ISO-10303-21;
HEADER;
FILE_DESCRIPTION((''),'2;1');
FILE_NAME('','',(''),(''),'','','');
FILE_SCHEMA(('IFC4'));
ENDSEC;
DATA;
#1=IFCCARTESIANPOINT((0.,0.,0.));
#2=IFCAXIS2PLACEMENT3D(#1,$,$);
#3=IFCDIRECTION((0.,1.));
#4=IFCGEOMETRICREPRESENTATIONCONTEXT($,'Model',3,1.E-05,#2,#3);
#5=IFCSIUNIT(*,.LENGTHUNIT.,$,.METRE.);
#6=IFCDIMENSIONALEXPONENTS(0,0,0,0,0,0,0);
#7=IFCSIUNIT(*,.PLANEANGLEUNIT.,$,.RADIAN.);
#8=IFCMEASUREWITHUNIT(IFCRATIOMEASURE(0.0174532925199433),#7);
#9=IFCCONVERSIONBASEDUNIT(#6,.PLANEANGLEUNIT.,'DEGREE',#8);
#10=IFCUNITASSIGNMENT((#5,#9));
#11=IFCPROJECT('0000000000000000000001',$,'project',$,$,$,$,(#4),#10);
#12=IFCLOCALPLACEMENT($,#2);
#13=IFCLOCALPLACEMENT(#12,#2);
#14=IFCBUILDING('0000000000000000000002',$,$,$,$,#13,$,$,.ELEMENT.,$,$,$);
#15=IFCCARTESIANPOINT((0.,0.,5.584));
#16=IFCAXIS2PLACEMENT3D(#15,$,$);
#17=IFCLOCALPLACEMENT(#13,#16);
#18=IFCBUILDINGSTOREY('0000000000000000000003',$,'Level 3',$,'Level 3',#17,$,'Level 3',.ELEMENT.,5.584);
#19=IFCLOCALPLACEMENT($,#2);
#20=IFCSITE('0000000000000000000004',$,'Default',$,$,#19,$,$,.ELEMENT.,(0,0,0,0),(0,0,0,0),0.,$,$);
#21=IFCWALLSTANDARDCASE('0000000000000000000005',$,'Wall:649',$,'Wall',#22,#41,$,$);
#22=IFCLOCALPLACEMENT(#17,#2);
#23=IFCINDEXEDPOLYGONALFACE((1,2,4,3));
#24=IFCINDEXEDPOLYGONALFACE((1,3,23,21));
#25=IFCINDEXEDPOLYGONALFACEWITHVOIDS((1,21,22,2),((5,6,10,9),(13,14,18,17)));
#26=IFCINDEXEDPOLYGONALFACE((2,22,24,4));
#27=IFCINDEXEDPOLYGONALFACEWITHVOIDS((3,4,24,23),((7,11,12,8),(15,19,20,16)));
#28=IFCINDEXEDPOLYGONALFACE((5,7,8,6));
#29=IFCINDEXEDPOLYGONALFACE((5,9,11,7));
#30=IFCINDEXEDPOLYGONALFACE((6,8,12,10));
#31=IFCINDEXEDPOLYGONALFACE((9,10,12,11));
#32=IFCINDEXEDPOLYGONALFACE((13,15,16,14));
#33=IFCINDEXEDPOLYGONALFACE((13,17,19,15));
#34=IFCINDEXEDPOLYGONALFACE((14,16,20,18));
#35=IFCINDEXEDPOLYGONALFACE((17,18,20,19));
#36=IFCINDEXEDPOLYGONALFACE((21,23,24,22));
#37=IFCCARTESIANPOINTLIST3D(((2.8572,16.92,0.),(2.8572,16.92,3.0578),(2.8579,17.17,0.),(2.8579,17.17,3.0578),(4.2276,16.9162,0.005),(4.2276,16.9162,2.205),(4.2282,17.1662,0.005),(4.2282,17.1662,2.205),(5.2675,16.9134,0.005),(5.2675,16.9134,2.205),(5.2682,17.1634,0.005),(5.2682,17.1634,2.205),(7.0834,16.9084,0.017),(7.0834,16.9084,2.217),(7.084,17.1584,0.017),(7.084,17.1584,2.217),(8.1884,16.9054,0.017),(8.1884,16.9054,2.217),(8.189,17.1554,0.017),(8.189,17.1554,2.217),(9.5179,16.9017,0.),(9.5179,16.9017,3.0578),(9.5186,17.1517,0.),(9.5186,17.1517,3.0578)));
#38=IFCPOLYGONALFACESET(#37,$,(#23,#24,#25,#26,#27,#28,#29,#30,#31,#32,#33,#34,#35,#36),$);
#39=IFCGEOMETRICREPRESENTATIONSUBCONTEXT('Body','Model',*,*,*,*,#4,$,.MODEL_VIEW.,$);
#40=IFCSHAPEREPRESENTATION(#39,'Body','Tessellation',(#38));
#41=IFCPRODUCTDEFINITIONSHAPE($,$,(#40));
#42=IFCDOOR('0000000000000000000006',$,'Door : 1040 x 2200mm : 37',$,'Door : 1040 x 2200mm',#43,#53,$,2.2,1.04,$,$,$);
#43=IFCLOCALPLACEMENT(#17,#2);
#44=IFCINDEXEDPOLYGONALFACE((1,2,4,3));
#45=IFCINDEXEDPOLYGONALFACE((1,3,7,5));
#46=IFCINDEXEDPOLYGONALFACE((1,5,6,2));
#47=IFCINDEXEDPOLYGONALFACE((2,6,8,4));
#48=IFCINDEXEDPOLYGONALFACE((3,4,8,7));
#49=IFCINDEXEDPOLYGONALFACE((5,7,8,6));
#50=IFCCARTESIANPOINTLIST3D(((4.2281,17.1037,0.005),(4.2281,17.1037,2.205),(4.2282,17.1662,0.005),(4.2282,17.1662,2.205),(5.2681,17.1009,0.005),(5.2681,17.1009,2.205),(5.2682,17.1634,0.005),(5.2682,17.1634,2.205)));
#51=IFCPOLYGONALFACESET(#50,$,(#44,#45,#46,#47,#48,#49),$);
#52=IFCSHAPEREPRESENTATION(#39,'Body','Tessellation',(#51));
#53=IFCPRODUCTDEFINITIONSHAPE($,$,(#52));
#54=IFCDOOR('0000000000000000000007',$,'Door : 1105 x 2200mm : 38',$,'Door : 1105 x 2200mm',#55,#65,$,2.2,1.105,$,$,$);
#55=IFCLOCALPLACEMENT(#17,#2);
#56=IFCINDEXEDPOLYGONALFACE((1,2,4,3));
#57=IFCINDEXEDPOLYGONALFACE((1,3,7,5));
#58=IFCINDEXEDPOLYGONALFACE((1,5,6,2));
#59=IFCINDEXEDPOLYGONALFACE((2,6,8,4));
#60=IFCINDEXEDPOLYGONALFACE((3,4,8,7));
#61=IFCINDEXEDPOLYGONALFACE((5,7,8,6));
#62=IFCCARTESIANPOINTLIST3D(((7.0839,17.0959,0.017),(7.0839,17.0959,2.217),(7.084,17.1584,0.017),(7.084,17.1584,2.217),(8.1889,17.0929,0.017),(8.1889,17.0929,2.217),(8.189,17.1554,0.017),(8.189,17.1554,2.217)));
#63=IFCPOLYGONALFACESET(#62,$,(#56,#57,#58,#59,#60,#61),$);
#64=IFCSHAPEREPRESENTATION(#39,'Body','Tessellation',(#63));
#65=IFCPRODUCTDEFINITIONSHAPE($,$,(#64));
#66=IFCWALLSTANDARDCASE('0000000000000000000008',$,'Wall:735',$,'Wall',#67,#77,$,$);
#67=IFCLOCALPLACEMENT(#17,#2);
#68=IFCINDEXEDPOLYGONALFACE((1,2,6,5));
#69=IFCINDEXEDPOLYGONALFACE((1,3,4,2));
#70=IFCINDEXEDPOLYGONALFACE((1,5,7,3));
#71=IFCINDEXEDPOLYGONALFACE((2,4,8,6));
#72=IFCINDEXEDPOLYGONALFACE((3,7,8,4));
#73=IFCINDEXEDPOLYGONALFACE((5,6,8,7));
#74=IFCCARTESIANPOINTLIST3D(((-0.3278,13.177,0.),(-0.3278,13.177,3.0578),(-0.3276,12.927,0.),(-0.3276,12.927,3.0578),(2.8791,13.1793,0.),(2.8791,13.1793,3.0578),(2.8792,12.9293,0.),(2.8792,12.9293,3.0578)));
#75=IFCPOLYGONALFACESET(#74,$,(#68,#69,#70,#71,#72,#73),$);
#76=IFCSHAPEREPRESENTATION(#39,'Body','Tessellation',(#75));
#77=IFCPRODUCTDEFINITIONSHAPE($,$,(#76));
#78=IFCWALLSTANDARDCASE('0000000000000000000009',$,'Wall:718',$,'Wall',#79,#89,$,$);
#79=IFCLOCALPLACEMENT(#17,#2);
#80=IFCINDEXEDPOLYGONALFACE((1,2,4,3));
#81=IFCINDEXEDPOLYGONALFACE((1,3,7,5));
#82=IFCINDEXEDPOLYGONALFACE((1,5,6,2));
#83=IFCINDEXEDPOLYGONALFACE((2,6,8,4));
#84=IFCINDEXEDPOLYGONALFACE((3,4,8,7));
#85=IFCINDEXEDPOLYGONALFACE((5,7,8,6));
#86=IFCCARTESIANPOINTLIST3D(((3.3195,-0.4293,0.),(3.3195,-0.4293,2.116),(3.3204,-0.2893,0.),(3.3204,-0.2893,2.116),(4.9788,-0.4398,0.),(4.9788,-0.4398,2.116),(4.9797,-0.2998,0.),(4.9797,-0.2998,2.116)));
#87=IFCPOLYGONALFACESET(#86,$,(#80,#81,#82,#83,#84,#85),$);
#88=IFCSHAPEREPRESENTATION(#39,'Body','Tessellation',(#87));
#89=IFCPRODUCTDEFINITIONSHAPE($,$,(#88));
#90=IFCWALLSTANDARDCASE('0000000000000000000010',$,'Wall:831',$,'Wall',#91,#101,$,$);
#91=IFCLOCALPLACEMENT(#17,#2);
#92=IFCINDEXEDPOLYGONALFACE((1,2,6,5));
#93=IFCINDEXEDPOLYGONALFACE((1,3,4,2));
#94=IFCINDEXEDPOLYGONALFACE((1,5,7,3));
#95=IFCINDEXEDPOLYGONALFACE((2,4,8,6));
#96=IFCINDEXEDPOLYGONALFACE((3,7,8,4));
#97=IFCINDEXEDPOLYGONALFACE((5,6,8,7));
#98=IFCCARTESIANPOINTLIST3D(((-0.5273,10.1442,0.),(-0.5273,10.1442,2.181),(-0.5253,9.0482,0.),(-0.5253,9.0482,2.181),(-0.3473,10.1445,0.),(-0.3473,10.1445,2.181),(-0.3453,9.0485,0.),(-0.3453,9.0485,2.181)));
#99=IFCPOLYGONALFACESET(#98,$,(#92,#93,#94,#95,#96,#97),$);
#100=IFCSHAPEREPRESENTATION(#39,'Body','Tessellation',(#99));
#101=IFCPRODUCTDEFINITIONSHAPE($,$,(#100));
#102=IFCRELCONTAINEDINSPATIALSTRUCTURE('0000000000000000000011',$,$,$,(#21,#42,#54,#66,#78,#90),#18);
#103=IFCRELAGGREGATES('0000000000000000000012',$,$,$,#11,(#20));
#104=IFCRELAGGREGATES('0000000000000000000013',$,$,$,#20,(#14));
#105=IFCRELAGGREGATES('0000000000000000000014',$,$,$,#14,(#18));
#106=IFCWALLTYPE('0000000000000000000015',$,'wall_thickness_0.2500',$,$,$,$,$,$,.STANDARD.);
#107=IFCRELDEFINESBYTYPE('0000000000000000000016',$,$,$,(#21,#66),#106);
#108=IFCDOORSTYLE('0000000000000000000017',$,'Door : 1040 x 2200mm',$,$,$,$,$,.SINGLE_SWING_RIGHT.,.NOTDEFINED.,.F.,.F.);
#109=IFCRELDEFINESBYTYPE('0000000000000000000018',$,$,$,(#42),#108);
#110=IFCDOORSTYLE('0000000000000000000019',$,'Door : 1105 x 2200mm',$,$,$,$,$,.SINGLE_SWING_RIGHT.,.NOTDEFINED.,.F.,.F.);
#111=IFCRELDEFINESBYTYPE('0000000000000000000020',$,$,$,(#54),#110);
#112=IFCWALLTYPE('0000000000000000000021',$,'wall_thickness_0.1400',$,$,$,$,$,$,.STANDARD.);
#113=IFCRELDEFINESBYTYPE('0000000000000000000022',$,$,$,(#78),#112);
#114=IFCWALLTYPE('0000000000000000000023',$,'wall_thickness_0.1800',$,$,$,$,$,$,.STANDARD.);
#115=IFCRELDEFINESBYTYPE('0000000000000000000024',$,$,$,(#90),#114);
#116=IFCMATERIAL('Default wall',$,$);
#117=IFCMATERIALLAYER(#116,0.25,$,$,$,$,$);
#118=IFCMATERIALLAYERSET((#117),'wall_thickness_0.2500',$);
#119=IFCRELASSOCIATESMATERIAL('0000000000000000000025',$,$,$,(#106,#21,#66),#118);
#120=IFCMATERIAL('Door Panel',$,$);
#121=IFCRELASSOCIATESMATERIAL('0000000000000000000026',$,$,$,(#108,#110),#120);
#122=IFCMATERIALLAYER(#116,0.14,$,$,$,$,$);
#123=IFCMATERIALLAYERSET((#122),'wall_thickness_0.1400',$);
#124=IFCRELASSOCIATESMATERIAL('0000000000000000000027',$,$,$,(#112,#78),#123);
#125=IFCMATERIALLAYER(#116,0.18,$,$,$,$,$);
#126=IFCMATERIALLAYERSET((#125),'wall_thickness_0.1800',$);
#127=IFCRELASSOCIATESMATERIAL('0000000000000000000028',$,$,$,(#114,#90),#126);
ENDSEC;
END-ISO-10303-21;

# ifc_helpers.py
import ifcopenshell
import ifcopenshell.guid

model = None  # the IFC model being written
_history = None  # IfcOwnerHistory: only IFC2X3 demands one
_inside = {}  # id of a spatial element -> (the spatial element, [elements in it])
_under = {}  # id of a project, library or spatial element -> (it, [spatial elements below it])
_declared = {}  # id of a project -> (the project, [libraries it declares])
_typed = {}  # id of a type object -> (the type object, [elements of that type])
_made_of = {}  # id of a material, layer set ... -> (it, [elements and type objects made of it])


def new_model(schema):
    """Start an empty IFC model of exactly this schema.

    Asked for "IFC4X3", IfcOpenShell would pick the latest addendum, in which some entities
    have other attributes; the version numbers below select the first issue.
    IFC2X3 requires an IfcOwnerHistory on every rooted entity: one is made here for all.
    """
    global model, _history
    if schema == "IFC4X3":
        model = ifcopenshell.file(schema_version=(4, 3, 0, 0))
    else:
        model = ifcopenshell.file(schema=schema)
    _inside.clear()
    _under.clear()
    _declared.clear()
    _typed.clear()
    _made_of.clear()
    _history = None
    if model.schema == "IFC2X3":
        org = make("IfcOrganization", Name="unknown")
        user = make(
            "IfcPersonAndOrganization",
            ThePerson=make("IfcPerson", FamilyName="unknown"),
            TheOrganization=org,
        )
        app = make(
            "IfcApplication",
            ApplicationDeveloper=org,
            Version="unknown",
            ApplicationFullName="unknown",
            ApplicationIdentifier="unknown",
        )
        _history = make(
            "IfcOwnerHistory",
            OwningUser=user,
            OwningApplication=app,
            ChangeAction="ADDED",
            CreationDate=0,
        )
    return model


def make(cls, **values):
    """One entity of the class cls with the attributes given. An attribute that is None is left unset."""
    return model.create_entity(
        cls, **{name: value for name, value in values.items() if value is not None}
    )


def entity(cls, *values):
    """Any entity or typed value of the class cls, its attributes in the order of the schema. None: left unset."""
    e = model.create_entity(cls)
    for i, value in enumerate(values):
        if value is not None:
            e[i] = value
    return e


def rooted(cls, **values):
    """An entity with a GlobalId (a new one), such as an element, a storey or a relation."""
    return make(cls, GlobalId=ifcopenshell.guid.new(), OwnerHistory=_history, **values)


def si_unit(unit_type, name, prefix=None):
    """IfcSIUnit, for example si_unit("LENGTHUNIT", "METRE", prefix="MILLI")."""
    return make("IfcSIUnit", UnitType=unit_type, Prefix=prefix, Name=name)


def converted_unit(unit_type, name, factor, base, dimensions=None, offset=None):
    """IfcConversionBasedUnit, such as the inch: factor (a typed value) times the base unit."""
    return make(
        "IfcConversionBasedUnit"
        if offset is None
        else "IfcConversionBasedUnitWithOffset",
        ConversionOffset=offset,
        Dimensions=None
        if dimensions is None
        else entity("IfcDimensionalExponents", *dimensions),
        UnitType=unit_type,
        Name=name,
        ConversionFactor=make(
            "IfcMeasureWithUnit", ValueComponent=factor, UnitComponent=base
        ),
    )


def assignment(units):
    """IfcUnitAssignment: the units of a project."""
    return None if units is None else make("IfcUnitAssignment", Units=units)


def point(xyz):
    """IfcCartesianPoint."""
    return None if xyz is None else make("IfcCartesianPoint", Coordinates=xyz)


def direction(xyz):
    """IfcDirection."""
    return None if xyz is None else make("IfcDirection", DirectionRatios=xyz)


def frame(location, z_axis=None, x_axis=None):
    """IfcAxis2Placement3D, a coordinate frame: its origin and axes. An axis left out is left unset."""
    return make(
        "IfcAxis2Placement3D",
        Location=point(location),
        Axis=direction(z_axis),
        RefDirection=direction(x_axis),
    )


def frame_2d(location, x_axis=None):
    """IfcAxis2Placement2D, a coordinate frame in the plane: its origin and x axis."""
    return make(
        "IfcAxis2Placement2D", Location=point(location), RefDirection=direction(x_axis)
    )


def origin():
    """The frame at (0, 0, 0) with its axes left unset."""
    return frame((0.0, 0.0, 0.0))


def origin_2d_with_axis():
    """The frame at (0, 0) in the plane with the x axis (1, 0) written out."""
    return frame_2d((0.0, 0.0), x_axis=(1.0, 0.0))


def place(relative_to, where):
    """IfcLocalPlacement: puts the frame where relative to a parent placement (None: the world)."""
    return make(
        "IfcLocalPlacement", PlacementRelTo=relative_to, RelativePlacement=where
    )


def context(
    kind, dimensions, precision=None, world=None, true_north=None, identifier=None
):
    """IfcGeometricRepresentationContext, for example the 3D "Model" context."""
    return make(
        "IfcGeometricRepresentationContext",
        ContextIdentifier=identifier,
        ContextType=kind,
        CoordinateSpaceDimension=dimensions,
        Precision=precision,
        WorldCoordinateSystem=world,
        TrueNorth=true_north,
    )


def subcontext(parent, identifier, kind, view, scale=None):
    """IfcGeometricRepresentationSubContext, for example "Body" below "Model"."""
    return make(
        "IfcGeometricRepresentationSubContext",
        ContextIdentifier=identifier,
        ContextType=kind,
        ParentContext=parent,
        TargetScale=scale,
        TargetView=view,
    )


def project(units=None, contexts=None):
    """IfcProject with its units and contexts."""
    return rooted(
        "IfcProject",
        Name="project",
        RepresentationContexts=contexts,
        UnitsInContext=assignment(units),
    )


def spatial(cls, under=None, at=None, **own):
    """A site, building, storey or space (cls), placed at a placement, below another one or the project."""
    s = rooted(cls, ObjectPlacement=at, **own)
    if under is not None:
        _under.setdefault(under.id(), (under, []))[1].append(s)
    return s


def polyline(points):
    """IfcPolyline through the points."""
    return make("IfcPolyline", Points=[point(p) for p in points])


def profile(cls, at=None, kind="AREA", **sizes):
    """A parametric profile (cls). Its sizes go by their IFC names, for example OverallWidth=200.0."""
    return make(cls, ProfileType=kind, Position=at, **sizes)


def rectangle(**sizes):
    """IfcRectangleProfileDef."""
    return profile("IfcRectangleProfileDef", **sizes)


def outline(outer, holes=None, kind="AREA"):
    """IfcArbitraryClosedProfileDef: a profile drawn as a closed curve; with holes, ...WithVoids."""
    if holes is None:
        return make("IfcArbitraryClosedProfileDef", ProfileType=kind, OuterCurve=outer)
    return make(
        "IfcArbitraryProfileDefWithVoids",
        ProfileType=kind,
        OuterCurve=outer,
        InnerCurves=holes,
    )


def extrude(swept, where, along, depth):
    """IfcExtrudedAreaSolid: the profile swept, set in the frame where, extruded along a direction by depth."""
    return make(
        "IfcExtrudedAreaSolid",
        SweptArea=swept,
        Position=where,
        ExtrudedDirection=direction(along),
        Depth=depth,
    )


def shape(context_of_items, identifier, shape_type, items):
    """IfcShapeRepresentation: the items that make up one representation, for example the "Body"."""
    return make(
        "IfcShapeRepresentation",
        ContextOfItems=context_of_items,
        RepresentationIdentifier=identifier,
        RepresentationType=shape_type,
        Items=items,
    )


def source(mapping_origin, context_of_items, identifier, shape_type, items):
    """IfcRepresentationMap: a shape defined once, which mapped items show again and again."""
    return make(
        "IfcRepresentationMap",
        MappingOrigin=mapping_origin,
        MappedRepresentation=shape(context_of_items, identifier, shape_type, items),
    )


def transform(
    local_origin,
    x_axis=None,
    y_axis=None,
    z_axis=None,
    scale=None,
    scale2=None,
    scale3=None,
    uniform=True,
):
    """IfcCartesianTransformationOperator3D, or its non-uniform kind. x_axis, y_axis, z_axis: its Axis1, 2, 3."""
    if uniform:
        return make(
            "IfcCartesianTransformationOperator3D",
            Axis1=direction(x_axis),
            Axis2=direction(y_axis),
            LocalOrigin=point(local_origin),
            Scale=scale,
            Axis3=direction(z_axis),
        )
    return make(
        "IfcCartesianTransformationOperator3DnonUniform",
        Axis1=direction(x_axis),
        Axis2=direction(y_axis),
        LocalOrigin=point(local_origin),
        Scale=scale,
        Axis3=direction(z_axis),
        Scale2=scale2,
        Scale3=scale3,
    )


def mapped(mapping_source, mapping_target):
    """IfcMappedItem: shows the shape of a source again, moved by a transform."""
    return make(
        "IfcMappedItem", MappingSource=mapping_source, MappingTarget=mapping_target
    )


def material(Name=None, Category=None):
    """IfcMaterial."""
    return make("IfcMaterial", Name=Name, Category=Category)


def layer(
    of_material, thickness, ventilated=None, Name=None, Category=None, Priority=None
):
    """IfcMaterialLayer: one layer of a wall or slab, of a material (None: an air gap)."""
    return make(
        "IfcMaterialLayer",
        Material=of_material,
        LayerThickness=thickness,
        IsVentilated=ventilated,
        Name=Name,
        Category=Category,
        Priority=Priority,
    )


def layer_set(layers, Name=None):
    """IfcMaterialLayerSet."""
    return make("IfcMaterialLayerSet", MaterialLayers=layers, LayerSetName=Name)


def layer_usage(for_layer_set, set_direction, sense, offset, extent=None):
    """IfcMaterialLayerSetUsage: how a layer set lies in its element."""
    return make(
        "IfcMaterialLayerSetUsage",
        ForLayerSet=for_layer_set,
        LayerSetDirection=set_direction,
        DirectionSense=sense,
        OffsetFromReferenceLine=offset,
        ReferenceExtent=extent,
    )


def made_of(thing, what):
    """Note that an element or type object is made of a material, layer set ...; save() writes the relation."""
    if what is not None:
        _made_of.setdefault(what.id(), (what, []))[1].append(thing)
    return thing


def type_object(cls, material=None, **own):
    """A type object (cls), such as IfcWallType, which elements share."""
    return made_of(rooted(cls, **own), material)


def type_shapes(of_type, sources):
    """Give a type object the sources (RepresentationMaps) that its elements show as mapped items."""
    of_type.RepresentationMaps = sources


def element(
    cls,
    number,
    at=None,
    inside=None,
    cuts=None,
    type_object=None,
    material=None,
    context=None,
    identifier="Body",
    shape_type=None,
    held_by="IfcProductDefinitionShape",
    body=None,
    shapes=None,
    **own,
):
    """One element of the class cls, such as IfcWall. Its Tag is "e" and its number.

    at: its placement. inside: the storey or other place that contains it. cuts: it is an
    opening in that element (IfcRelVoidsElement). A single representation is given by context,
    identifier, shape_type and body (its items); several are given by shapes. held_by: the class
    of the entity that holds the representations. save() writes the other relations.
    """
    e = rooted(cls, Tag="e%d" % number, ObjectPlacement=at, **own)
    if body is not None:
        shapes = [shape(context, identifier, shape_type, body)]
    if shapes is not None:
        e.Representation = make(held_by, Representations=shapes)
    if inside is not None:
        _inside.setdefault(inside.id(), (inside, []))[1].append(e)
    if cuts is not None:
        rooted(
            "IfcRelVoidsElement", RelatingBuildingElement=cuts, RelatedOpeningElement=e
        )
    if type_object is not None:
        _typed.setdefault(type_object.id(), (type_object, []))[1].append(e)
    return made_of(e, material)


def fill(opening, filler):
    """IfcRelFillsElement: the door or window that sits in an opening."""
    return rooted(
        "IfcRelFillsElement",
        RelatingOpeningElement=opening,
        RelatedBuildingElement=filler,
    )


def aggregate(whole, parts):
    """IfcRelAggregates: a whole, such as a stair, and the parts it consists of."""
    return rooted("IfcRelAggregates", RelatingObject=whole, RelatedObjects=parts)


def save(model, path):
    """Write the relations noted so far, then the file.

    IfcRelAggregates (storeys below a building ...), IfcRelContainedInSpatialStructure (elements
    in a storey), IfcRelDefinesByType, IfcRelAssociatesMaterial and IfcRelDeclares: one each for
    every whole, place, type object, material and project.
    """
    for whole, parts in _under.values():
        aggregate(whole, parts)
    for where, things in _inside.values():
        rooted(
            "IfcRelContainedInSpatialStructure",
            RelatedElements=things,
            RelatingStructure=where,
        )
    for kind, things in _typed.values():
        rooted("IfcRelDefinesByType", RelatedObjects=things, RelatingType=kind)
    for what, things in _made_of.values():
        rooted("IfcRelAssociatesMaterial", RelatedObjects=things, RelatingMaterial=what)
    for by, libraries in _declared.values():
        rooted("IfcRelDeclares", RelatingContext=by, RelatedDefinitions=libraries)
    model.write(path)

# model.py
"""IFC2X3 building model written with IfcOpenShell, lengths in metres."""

from ifc_helpers import new_model, entity, si_unit, converted_unit, direction, frame, frame_2d, origin, origin_2d_with_axis, place, context, subcontext, project, spatial, polyline, rectangle, outline, extrude, source, transform, mapped, material, layer, layer_set, layer_usage, type_object, type_shapes, element, fill, save


model = new_model("IFC2X3")

# Units and contexts
model_context = context("Model", 3, precision=1e-05, world=origin(), true_north=direction((0.0, 1.0)))
body_context = subcontext(model_context, "Body", "Model", "MODEL_VIEW")
ifc_project = project(units=[si_unit("LENGTHUNIT", "METRE"), converted_unit("PLANEANGLEUNIT", "DEGREE", entity("IfcRatioMeasure", 0.0174532925199433), si_unit("PLANEANGLEUNIT", "RADIAN"), dimensions=[0, 0, 0, 0, 0, 0, 0])], contexts=[model_context])

# Site, building, storey
site_placement = place(None, origin())
site = spatial("IfcSite", under=ifc_project, at=site_placement, Name="Default", CompositionType="ELEMENT", RefLatitude=(0, 0, 0, 0), RefLongitude=(0, 0, 0, 0), RefElevation=0.0)
placement_1 = place(None, origin())
building_placement = place(placement_1, origin())
building = spatial("IfcBuilding", under=site, at=building_placement, CompositionType="ELEMENT")
storey_placement = place(building_placement, frame((0.0, 0.0, 5.584)))
storey = spatial("IfcBuildingStorey", under=building, at=storey_placement, Name="Level 3", ObjectType="Level 3", LongName="Level 3", CompositionType="ELEMENT", Elevation=5.584)

# Shared definitions
ifc_material_1 = material(Name="Default wall")

# Wall, openings, doors
ifc_layer_1 = layer(ifc_material_1, 0.25)
ifc_layer_set_1 = layer_set([ifc_layer_1], Name="wall_thickness_0.2500")
ifc_layer_usage_1 = layer_usage(ifc_layer_set_1, "AXIS2", "POSITIVE", -0.125)
wall_type_1 = type_object("IfcWallType", Name="wall_thickness_0.2500", PredefinedType="STANDARD", material=ifc_layer_set_1)
wall_1_placement = place(storey_placement, frame((2.8576, 17.045, 0.0), z_axis=(0.0, 0.0, 1.0), x_axis=(0.999996, -0.002747, 0.0)))
wall_1 = element("IfcWallStandardCase", 1, at=wall_1_placement, inside=storey, type_object=wall_type_1, material=ifc_layer_usage_1, Name="Wall:649", ObjectType="Wall", context=body_context, shape_type="SweptSolid", body=[
    extrude(outline(polyline([(6.6607, -0.125), (6.6607, 0.125), (0.0, 0.125), (0.0, -0.125), (6.6607, -0.125)])), origin(), (0.0, 0.0, 1.0), 3.0578),
])
opening_1_placement = place(wall_1_placement, frame((1.3703, -0.125, 0.005)))
opening_1 = element("IfcOpeningElement", 2, at=opening_1_placement, cuts=wall_1, ObjectType="Opening", context=body_context, shape_type="SweptSolid", body=[
    extrude(rectangle(XDim=1.04, YDim=2.2, at=frame_2d((1.1, 0.52), x_axis=(0.0, 1.0))), frame((0.0, 0.0, 0.0), z_axis=(0.0, 1.0, 0.0), x_axis=(0.0, 0.0, 1.0)), (0.0, 0.0, 1.0), 0.25),
])
opening_2_placement = place(wall_1_placement, frame((4.2261, -0.125, 0.017)))
opening_2 = element("IfcOpeningElement", 3, at=opening_2_placement, cuts=wall_1, ObjectType="Opening", context=body_context, shape_type="SweptSolid", body=[
    extrude(rectangle(XDim=1.105, YDim=2.2, at=frame_2d((1.1, 0.5525), x_axis=(0.0, 1.0))), frame((0.0, 0.0, 0.0), z_axis=(0.0, 1.0, 0.0), x_axis=(0.0, 0.0, 1.0)), (0.0, 0.0, 1.0), 0.25),
])
ifc_material_2 = material(Name="Door Panel")
door_style_1 = type_object("IfcDoorStyle", Name="Door : 1040 x 2200mm", ConstructionType="NOTDEFINED", OperationType="SINGLE_SWING_RIGHT", ParameterTakesPrecedence=False, Sizeable=False, material=ifc_material_2)
shared_shape_1 = source(origin(), body_context, "Body", "SweptSolid", [
    extrude(rectangle(XDim=0.0625, YDim=1.04, at=origin_2d_with_axis()), frame((0.52, 0.2188, 0.0), z_axis=(0.0, 0.0, 1.0), x_axis=(0.0, 1.0, 0.0)), (0.0, 0.0, 1.0), 2.2),
])
type_shapes(door_style_1, [shared_shape_1])
door_1_placement = place(opening_1_placement, origin())
door_1 = element("IfcDoor", 4, at=door_1_placement, inside=storey, type_object=door_style_1, Name="Door : 1040 x 2200mm : 37", ObjectType="Door : 1040 x 2200mm", OverallHeight=2.2, OverallWidth=1.04, context=body_context, shape_type="MappedRepresentation", body=[
    mapped(shared_shape_1, transform((0.0, 0.0, 0.0), scale=1.0)),
])
fill(opening_1, door_1)
door_style_2 = type_object("IfcDoorStyle", Name="Door : 1105 x 2200mm", ConstructionType="NOTDEFINED", OperationType="SINGLE_SWING_RIGHT", ParameterTakesPrecedence=False, Sizeable=False, material=ifc_material_2)
shared_shape_2 = source(origin(), body_context, "Body", "SweptSolid", [
    extrude(rectangle(XDim=0.0625, YDim=1.105, at=origin_2d_with_axis()), frame((0.5525, 0.2188, 0.0), z_axis=(0.0, 0.0, 1.0), x_axis=(0.0, 1.0, 0.0)), (0.0, 0.0, 1.0), 2.2),
])
type_shapes(door_style_2, [shared_shape_2])
door_2_placement = place(opening_2_placement, origin())
door_2 = element("IfcDoor", 5, at=door_2_placement, inside=storey, type_object=door_style_2, Name="Door : 1105 x 2200mm : 38", ObjectType="Door : 1105 x 2200mm", OverallHeight=2.2, OverallWidth=1.105, context=body_context, shape_type="MappedRepresentation", body=[
    mapped(shared_shape_2, transform((0.0, 0.0, 0.0), scale=1.0)),
])
fill(opening_2, door_2)

# Walls
wall_2_placement = place(storey_placement, frame((-0.3277, 13.052, 0.0), z_axis=(0.0, 0.0, 1.0), x_axis=(1.0, 0.00071, 0.0)))
element("IfcWallStandardCase", 6, at=wall_2_placement, inside=storey, type_object=wall_type_1, material=ifc_layer_usage_1, Name="Wall:735", ObjectType="Wall", context=body_context, shape_type="SweptSolid", body=[
    extrude(outline(polyline([(3.2069, -0.125), (3.2069, 0.125), (0.0, 0.125), (0.0, -0.125), (3.2069, -0.125)])), origin(), (0.0, 0.0, 1.0), 3.0578),
])
ifc_layer_2 = layer(ifc_material_1, 0.14)
ifc_layer_set_2 = layer_set([ifc_layer_2], Name="wall_thickness_0.1400")
ifc_layer_usage_2 = layer_usage(ifc_layer_set_2, "AXIS2", "POSITIVE", -0.07)
wall_type_2 = type_object("IfcWallType", Name="wall_thickness_0.1400", PredefinedType="STANDARD", material=ifc_layer_set_2)
wall_3_placement = place(storey_placement, frame((3.3199, -0.3593, 0.0), z_axis=(0.0, 0.0, 1.0), x_axis=(0.99998, -0.006318, 0.0)))
element("IfcWallStandardCase", 7, at=wall_3_placement, inside=storey, type_object=wall_type_2, material=ifc_layer_usage_2, Name="Wall:718", ObjectType="Wall", context=body_context, shape_type="SweptSolid", body=[
    extrude(outline(polyline([(1.6594, -0.07), (1.6594, 0.07), (0.0, 0.07), (0.0, -0.07), (1.6594, -0.07)])), origin(), (0.0, 0.0, 1.0), 2.116),
])
ifc_layer_3 = layer(ifc_material_1, 0.18)
ifc_layer_set_3 = layer_set([ifc_layer_3], Name="wall_thickness_0.1800")
ifc_layer_usage_3 = layer_usage(ifc_layer_set_3, "AXIS2", "POSITIVE", -0.09)
wall_type_3 = type_object("IfcWallType", Name="wall_thickness_0.1800", PredefinedType="STANDARD", material=ifc_layer_set_3)
wall_4_placement = place(storey_placement, frame((-0.4373, 10.1443, 0.0), z_axis=(0.0, 0.0, 1.0), x_axis=(0.001822, -0.999998, 0.0)))
element("IfcWallStandardCase", 8, at=wall_4_placement, inside=storey, type_object=wall_type_3, material=ifc_layer_usage_3, Name="Wall:831", ObjectType="Wall", context=body_context, shape_type="SweptSolid", body=[
    extrude(outline(polyline([(1.096, -0.09), (1.096, 0.09), (0.0, 0.09), (0.0, -0.09), (1.096, -0.09)])), origin(), (0.0, 0.0, 1.0), 2.181),
])

save(model, "model.ifc")
